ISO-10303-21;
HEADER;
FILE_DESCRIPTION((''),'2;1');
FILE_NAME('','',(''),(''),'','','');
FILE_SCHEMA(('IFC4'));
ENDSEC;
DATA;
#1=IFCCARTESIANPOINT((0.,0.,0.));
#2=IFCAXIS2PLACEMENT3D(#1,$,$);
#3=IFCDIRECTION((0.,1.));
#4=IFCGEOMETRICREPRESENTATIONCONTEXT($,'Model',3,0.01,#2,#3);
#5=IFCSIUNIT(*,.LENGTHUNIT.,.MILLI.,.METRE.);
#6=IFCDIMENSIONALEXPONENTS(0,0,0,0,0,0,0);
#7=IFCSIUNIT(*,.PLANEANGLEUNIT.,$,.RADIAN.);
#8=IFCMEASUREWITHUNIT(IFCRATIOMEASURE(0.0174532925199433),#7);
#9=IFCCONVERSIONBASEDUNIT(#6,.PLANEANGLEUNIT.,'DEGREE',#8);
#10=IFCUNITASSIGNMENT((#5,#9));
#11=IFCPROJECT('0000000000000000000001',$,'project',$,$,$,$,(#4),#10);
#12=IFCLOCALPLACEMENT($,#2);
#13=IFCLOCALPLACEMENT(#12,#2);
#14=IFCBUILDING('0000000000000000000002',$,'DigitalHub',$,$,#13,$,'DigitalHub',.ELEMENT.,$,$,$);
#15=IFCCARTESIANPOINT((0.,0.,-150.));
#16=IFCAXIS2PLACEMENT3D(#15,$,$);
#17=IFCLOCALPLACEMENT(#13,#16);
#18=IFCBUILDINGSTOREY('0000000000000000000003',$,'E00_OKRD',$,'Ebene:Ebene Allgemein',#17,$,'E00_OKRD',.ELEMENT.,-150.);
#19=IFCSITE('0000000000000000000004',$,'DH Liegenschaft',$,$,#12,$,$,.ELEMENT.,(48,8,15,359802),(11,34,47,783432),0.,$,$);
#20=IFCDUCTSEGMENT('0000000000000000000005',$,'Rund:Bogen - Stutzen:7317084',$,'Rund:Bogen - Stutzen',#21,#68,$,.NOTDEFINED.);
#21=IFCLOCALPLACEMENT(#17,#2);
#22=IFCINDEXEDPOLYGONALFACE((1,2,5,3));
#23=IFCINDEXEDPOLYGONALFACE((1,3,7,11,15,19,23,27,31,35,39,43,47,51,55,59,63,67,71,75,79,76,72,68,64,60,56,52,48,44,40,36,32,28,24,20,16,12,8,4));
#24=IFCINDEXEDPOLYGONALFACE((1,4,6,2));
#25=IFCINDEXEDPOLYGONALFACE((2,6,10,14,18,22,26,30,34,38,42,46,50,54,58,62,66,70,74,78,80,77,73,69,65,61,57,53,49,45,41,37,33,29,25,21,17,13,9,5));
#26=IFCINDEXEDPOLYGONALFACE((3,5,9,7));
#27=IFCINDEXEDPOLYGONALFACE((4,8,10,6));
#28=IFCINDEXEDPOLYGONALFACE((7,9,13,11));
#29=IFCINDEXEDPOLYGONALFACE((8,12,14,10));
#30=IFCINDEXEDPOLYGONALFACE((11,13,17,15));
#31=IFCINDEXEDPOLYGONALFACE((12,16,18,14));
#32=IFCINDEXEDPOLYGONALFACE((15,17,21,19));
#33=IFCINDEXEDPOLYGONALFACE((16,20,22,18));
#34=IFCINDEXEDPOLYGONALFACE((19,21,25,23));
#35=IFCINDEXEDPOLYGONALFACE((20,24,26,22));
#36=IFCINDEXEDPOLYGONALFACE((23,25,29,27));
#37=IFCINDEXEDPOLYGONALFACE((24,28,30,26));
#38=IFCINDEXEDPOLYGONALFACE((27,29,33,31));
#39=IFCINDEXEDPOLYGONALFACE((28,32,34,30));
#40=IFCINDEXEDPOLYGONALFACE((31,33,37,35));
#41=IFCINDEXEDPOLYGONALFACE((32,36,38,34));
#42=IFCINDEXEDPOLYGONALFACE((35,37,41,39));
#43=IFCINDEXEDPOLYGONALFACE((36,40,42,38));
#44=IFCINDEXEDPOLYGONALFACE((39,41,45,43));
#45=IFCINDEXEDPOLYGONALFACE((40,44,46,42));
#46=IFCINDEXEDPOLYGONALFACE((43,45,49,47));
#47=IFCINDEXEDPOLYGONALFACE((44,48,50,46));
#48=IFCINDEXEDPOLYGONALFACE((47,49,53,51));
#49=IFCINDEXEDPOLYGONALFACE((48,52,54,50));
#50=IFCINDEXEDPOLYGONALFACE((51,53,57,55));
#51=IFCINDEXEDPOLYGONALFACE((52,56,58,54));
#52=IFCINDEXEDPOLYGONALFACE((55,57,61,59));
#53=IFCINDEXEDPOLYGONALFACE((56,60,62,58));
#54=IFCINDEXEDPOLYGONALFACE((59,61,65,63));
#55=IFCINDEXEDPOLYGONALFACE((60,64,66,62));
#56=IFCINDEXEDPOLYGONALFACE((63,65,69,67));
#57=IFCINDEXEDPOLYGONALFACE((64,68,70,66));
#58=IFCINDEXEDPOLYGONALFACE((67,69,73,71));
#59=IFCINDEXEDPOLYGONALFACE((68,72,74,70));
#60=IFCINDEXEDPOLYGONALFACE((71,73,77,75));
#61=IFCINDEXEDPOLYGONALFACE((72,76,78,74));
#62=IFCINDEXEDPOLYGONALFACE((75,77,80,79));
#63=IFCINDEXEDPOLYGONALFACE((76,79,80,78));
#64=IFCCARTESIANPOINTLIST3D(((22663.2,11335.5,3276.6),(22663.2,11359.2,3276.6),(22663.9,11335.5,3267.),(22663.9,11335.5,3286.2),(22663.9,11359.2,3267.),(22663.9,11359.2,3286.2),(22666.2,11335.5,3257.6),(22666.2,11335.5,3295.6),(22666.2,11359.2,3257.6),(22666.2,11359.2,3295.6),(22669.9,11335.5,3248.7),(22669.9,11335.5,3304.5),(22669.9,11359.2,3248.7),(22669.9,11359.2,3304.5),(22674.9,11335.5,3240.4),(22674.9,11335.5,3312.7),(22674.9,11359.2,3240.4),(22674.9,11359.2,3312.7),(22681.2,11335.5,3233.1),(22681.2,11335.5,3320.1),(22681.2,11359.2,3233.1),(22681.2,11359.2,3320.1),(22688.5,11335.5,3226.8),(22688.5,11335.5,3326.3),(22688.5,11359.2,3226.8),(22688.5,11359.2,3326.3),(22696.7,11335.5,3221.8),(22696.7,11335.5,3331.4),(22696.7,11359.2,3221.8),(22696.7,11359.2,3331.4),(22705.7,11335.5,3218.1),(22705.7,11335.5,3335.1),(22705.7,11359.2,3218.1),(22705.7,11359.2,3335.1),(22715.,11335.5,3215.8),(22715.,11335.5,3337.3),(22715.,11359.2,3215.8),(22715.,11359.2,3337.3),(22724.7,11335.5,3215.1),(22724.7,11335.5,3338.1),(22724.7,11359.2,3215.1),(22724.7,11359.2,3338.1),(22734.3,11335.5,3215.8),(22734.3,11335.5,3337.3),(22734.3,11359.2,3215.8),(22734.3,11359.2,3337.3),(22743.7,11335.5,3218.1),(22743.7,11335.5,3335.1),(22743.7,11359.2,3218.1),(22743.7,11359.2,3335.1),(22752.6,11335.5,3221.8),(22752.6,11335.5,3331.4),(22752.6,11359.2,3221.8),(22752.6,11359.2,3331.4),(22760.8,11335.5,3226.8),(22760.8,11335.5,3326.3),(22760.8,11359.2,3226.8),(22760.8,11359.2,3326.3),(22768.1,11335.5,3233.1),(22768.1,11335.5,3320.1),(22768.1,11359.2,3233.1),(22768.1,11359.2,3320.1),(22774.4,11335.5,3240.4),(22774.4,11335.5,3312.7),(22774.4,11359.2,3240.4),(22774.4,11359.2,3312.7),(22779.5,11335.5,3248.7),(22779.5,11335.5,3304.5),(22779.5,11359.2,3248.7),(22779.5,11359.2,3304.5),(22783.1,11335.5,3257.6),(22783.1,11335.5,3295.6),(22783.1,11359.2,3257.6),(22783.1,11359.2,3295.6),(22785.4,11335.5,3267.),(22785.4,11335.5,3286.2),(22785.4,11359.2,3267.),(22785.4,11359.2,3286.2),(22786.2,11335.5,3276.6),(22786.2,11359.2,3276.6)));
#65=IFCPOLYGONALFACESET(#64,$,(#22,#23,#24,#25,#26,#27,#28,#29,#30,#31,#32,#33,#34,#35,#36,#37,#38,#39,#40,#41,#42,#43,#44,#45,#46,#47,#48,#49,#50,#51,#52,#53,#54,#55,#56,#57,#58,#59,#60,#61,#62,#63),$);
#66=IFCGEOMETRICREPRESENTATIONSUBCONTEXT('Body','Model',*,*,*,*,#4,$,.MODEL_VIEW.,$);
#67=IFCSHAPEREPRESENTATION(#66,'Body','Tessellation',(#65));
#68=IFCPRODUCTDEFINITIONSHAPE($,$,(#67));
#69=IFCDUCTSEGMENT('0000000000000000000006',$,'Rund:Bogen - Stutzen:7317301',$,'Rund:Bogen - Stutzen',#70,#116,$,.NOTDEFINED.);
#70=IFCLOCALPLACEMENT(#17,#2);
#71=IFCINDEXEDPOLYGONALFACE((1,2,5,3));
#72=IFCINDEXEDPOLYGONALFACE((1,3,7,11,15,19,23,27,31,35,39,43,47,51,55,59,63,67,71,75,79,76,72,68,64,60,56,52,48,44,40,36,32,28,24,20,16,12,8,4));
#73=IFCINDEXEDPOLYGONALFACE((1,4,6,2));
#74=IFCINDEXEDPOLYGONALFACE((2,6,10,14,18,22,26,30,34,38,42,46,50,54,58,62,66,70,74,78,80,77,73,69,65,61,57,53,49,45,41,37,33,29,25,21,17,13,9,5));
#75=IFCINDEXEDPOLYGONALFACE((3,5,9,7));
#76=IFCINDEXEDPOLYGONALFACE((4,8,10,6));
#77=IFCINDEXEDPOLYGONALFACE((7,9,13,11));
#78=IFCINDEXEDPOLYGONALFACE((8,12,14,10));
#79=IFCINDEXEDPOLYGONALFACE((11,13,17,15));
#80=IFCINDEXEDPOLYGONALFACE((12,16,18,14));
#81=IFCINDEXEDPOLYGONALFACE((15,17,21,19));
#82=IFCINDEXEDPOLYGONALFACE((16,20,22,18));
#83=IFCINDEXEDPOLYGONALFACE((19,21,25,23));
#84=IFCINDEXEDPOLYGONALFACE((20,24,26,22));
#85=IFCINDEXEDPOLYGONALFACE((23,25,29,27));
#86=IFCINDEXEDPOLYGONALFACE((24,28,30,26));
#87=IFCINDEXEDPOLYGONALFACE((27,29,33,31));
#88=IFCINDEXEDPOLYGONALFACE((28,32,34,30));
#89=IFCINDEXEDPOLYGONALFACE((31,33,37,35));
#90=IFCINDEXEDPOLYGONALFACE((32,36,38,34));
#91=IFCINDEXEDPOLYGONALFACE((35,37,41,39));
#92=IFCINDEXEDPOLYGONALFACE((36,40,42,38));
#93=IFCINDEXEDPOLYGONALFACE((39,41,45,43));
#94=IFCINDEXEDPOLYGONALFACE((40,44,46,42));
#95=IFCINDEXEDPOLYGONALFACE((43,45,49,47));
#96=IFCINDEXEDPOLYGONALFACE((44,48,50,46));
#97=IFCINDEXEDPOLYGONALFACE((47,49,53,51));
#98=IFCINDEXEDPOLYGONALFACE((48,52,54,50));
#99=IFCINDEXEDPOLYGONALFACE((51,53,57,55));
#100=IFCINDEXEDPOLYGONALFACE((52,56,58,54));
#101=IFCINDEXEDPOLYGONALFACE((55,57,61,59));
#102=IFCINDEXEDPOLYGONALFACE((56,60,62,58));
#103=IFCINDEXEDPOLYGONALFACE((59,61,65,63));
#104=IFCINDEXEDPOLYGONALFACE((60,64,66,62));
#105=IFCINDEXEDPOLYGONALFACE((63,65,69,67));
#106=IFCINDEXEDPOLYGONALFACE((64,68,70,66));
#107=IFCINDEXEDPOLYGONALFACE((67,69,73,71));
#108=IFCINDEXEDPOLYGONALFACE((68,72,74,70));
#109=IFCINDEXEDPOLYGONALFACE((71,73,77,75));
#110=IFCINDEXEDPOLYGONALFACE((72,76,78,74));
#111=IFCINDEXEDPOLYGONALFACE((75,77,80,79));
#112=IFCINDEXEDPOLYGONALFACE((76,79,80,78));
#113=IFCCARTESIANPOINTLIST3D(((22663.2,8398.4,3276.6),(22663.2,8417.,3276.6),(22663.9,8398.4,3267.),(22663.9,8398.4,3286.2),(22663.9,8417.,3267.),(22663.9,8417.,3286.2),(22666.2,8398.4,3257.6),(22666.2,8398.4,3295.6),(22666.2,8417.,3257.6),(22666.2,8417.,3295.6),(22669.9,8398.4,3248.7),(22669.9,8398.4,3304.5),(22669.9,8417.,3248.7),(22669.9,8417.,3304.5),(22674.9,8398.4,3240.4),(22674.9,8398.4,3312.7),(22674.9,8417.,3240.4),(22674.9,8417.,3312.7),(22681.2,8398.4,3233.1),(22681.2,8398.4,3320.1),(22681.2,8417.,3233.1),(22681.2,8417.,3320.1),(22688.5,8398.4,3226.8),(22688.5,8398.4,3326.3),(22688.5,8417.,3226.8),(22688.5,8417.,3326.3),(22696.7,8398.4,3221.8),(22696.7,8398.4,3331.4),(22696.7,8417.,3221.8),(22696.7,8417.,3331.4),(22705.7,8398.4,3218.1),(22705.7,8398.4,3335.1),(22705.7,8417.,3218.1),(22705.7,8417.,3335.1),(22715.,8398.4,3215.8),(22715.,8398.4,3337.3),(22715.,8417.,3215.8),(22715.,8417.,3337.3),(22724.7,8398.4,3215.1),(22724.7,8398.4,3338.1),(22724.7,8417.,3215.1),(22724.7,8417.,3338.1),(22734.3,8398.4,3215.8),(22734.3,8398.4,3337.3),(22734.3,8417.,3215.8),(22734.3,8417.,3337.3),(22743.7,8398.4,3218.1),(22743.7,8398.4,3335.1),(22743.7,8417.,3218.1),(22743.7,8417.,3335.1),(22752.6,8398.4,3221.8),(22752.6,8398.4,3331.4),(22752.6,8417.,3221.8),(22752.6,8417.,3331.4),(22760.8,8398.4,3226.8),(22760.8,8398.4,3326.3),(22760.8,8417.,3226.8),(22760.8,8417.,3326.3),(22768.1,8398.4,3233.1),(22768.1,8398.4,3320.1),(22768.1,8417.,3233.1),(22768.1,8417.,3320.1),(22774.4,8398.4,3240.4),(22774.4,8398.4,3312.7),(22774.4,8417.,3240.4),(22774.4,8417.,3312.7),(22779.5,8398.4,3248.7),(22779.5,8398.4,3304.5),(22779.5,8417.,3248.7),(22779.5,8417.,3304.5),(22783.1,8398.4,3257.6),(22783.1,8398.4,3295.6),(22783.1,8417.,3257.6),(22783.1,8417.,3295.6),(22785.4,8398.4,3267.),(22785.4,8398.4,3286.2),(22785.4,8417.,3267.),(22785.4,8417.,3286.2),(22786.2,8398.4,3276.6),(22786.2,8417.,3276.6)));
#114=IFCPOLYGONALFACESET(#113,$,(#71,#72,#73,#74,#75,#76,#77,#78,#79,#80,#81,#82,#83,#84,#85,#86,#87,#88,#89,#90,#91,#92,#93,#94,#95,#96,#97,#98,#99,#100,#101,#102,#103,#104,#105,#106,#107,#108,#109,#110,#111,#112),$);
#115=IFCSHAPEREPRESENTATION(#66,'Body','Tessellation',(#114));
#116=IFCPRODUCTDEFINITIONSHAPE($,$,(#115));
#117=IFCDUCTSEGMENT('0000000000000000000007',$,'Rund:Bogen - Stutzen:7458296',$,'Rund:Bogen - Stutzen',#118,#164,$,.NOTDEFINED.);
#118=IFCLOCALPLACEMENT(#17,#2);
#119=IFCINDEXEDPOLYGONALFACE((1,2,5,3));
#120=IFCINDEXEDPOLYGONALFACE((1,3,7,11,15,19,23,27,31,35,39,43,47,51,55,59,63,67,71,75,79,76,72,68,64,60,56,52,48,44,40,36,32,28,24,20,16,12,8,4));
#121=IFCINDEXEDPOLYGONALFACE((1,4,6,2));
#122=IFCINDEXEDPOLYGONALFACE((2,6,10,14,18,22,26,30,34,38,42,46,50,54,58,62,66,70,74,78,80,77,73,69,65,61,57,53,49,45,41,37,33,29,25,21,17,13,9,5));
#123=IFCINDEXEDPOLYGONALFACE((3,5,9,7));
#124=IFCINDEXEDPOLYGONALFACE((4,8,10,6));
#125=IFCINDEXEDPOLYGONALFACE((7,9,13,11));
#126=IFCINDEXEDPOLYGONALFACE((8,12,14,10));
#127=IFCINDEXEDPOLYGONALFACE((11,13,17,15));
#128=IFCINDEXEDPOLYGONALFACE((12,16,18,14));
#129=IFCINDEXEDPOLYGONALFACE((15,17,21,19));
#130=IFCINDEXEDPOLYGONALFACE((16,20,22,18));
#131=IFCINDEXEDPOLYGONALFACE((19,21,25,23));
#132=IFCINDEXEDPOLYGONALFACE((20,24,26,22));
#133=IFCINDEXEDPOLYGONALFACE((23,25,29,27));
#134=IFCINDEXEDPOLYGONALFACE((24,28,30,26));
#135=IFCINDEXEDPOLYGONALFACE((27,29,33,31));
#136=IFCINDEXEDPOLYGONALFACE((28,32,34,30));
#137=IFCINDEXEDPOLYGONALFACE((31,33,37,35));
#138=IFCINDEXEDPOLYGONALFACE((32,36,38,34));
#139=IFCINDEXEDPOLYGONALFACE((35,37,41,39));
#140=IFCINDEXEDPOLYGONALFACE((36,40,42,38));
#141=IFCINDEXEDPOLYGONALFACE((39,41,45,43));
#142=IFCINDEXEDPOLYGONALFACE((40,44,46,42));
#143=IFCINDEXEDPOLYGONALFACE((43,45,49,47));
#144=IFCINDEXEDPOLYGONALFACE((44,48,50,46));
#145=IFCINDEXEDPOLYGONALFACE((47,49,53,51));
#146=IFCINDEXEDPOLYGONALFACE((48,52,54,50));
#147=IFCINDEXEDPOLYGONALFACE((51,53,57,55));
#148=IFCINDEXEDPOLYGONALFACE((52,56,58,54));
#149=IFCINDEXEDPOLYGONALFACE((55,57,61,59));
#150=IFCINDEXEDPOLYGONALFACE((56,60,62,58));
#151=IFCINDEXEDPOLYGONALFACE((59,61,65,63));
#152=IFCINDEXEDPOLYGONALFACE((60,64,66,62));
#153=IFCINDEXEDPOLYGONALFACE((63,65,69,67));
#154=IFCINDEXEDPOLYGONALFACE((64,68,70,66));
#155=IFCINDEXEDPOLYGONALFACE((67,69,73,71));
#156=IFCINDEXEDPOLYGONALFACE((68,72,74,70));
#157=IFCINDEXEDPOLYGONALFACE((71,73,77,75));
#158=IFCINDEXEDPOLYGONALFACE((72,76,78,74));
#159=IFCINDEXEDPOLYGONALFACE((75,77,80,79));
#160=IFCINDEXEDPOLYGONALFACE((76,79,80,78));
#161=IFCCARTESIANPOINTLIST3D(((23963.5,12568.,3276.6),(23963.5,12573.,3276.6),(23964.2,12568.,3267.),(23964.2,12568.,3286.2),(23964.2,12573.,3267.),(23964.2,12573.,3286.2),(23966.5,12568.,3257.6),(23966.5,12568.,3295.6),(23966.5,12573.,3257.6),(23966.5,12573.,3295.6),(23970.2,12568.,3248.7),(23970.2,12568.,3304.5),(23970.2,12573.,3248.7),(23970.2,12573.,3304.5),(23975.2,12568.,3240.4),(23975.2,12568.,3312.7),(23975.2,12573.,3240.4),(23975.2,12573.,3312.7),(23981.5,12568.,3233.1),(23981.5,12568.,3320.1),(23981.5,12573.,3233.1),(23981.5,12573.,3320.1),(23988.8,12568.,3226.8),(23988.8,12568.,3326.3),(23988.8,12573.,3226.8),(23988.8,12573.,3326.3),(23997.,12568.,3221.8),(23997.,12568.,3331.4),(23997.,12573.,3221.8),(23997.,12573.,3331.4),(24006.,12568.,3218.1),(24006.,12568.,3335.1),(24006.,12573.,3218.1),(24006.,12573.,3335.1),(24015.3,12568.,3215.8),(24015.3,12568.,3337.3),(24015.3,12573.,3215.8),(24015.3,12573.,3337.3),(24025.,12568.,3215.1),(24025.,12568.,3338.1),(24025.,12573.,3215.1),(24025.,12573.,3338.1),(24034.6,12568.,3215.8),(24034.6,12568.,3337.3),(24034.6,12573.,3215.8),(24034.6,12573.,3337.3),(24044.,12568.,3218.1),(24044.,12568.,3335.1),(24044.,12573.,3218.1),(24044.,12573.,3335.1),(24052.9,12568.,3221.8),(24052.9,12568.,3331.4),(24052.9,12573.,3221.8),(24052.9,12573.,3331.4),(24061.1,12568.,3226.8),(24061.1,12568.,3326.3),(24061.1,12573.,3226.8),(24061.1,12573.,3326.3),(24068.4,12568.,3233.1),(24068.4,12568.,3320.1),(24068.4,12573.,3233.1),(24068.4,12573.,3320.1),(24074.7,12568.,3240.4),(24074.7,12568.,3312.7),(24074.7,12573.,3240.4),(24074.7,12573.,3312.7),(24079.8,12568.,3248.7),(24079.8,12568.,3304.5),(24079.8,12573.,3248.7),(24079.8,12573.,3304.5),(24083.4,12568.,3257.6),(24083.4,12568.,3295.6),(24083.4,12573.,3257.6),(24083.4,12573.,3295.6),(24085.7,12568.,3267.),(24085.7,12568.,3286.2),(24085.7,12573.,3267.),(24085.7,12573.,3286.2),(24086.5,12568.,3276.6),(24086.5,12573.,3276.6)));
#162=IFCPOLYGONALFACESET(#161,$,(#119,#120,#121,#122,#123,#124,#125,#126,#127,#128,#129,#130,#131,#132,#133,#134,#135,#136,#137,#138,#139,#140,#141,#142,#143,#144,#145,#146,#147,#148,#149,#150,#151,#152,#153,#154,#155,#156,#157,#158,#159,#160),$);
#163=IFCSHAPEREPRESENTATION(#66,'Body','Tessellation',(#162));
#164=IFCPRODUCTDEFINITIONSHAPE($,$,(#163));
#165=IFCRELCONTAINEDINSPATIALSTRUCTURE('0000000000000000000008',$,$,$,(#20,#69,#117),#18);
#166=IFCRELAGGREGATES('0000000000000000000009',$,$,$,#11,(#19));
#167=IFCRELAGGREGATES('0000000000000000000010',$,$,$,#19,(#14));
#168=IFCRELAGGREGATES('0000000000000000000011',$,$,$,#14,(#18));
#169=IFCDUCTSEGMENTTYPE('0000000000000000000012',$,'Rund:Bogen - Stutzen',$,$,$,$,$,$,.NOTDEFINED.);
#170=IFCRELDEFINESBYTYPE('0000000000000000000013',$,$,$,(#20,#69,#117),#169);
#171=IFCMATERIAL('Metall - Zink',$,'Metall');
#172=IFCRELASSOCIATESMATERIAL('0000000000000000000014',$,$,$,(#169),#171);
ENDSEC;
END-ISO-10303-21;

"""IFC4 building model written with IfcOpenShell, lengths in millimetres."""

from ifc_helpers import new_model, entity, si_unit, converted_unit, direction, frame, origin, place, context, subcontext, project, spatial, indexed_curve, outline, extrude, material, type_object, element, save


model = new_model("IFC4")

# Units and contexts
model_context = context("Model", 3, precision=0.01, world=origin(), true_north=direction((0.0, 1.0)))
body_context = subcontext(model_context, "Body", "Model", "MODEL_VIEW")
ifc_project = project(units=[si_unit("LENGTHUNIT", "METRE", prefix="MILLI"), converted_unit("PLANEANGLEUNIT", "DEGREE", entity("IfcRatioMeasure", 0.0174532925199433), si_unit("PLANEANGLEUNIT", "RADIAN"), dimensions=[0, 0, 0, 0, 0, 0, 0])], contexts=[model_context])

# Site, building, storey
site_placement = place(None, origin())
site = spatial("IfcSite", under=ifc_project, at=site_placement, Name="DH Liegenschaft", CompositionType="ELEMENT", RefLatitude=(48, 8, 15, 359802), RefLongitude=(11, 34, 47, 783432), RefElevation=0.0)
building_placement = place(site_placement, origin())
building = spatial("IfcBuilding", under=site, at=building_placement, Name="DigitalHub", LongName="DigitalHub", CompositionType="ELEMENT")
storey_placement = place(building_placement, frame((0.0, 0.0, -150.0)))
storey = spatial("IfcBuildingStorey", under=building, at=storey_placement, Name="E00_OKRD", ObjectType="Ebene:Ebene Allgemein", LongName="E00_OKRD", CompositionType="ELEMENT", Elevation=-150.0)

# Duct segments
ifc_material_1 = material(Name="Metall - Zink", Category="Metall")
duct_segment_type_1 = type_object("IfcDuctSegmentType", Name="Rund:Bogen - Stutzen", PredefinedType="NOTDEFINED", material=ifc_material_1)
duct_segment_1_placement = place(storey_placement, frame((22661.6, 11335.5, 3213.5)))
element("IfcDuctSegment", 1, at=duct_segment_1_placement, inside=storey, type_object=duct_segment_type_1, Name="Rund:Bogen - Stutzen:7317084", ObjectType="Rund:Bogen - Stutzen", PredefinedType="NOTDEFINED", context=body_context, shape_type="SweptSolid", body=[
    extrude(outline(indexed_curve([(61.5, 0.0), (60.7, 9.6), (58.5, 19.0), (54.8, 27.9), (49.8, 36.1), (43.5, 43.5), (36.1, 49.8), (27.9, 54.8), (19.0, 58.5), (9.6, 60.7), (0.0, 61.5), (-9.6, 60.7), (-19.0, 58.5), (-27.9, 54.8), (-36.1, 49.8), (-43.5, 43.5), (-49.8, 36.1), (-54.8, 27.9), (-58.5, 19.0), (-60.7, 9.6), (-61.5, 0.0), (-60.7, -9.6), (-58.5, -19.0), (-54.8, -27.9), (-49.8, -36.1), (-43.5, -43.5), (-36.1, -49.8), (-27.9, -54.8), (-19.0, -58.5), (-9.6, -60.7), (0.0, -61.5), (9.6, -60.7), (19.0, -58.5), (27.9, -54.8), (36.1, -49.8), (43.5, -43.5), (49.8, -36.1), (54.8, -27.9), (58.5, -19.0), (60.7, -9.6), (61.5, 0.0)], self_intersect=False)), frame((63.1, 0.0, 63.1), z_axis=(0.0, 1.0, 0.0), x_axis=(-1.0, 0.0, 0.0)), (0.0, 0.0, 1.0), 23.8),
])
duct_segment_2_placement = place(storey_placement, frame((22661.6, 8398.4, 3213.5)))
element("IfcDuctSegment", 2, at=duct_segment_2_placement, inside=storey, type_object=duct_segment_type_1, Name="Rund:Bogen - Stutzen:7317301", ObjectType="Rund:Bogen - Stutzen", PredefinedType="NOTDEFINED", context=body_context, shape_type="SweptSolid", body=[
    extrude(outline(indexed_curve([(61.5, 0.0), (60.7, 9.6), (58.5, 19.0), (54.8, 27.9), (49.8, 36.1), (43.5, 43.5), (36.1, 49.8), (27.9, 54.8), (19.0, 58.5), (9.6, 60.7), (0.0, 61.5), (-9.6, 60.7), (-19.0, 58.5), (-27.9, 54.8), (-36.1, 49.8), (-43.5, 43.5), (-49.8, 36.1), (-54.8, 27.9), (-58.5, 19.0), (-60.7, 9.6), (-61.5, 0.0), (-60.7, -9.6), (-58.5, -19.0), (-54.8, -27.9), (-49.8, -36.1), (-43.5, -43.5), (-36.1, -49.8), (-27.9, -54.8), (-19.0, -58.5), (-9.6, -60.7), (0.0, -61.5), (9.6, -60.7), (19.0, -58.5), (27.9, -54.8), (36.1, -49.8), (43.5, -43.5), (49.8, -36.1), (54.8, -27.9), (58.5, -19.0), (60.7, -9.6), (61.5, 0.0)], self_intersect=False)), frame((63.1, 0.0, 63.1), z_axis=(0.0, 1.0, 0.0), x_axis=(1.0, 0.0, 0.0)), (0.0, 0.0, 1.0), 18.5),
])
duct_segment_3_placement = place(storey_placement, frame((23961.9, 12568.0, 3213.5)))
element("IfcDuctSegment", 3, at=duct_segment_3_placement, inside=storey, type_object=duct_segment_type_1, Name="Rund:Bogen - Stutzen:7458296", ObjectType="Rund:Bogen - Stutzen", PredefinedType="NOTDEFINED", context=body_context, shape_type="SweptSolid", body=[
    extrude(outline(indexed_curve([(61.5, 0.0), (60.7, 9.6), (58.5, 19.0), (54.8, 27.9), (49.8, 36.1), (43.5, 43.5), (36.1, 49.8), (27.9, 54.8), (19.0, 58.5), (9.6, 60.7), (0.0, 61.5), (-9.6, 60.7), (-19.0, 58.5), (-27.9, 54.8), (-36.1, 49.8), (-43.5, 43.5), (-49.8, 36.1), (-54.8, 27.9), (-58.5, 19.0), (-60.7, 9.6), (-61.5, 0.0), (-60.7, -9.6), (-58.5, -19.0), (-54.8, -27.9), (-49.8, -36.1), (-43.5, -43.5), (-36.1, -49.8), (-27.9, -54.8), (-19.0, -58.5), (-9.6, -60.7), (0.0, -61.5), (9.6, -60.7), (19.0, -58.5), (27.9, -54.8), (36.1, -49.8), (43.5, -43.5), (49.8, -36.1), (54.8, -27.9), (58.5, -19.0), (60.7, -9.6), (61.5, 0.0)], self_intersect=False)), frame((63.1, 0.0, 63.1), z_axis=(0.0, 1.0, 0.0), x_axis=(1.0, 0.0, 0.0)), (0.0, 0.0, 1.0), 5.0),
])

save(model, "model.ifc")
